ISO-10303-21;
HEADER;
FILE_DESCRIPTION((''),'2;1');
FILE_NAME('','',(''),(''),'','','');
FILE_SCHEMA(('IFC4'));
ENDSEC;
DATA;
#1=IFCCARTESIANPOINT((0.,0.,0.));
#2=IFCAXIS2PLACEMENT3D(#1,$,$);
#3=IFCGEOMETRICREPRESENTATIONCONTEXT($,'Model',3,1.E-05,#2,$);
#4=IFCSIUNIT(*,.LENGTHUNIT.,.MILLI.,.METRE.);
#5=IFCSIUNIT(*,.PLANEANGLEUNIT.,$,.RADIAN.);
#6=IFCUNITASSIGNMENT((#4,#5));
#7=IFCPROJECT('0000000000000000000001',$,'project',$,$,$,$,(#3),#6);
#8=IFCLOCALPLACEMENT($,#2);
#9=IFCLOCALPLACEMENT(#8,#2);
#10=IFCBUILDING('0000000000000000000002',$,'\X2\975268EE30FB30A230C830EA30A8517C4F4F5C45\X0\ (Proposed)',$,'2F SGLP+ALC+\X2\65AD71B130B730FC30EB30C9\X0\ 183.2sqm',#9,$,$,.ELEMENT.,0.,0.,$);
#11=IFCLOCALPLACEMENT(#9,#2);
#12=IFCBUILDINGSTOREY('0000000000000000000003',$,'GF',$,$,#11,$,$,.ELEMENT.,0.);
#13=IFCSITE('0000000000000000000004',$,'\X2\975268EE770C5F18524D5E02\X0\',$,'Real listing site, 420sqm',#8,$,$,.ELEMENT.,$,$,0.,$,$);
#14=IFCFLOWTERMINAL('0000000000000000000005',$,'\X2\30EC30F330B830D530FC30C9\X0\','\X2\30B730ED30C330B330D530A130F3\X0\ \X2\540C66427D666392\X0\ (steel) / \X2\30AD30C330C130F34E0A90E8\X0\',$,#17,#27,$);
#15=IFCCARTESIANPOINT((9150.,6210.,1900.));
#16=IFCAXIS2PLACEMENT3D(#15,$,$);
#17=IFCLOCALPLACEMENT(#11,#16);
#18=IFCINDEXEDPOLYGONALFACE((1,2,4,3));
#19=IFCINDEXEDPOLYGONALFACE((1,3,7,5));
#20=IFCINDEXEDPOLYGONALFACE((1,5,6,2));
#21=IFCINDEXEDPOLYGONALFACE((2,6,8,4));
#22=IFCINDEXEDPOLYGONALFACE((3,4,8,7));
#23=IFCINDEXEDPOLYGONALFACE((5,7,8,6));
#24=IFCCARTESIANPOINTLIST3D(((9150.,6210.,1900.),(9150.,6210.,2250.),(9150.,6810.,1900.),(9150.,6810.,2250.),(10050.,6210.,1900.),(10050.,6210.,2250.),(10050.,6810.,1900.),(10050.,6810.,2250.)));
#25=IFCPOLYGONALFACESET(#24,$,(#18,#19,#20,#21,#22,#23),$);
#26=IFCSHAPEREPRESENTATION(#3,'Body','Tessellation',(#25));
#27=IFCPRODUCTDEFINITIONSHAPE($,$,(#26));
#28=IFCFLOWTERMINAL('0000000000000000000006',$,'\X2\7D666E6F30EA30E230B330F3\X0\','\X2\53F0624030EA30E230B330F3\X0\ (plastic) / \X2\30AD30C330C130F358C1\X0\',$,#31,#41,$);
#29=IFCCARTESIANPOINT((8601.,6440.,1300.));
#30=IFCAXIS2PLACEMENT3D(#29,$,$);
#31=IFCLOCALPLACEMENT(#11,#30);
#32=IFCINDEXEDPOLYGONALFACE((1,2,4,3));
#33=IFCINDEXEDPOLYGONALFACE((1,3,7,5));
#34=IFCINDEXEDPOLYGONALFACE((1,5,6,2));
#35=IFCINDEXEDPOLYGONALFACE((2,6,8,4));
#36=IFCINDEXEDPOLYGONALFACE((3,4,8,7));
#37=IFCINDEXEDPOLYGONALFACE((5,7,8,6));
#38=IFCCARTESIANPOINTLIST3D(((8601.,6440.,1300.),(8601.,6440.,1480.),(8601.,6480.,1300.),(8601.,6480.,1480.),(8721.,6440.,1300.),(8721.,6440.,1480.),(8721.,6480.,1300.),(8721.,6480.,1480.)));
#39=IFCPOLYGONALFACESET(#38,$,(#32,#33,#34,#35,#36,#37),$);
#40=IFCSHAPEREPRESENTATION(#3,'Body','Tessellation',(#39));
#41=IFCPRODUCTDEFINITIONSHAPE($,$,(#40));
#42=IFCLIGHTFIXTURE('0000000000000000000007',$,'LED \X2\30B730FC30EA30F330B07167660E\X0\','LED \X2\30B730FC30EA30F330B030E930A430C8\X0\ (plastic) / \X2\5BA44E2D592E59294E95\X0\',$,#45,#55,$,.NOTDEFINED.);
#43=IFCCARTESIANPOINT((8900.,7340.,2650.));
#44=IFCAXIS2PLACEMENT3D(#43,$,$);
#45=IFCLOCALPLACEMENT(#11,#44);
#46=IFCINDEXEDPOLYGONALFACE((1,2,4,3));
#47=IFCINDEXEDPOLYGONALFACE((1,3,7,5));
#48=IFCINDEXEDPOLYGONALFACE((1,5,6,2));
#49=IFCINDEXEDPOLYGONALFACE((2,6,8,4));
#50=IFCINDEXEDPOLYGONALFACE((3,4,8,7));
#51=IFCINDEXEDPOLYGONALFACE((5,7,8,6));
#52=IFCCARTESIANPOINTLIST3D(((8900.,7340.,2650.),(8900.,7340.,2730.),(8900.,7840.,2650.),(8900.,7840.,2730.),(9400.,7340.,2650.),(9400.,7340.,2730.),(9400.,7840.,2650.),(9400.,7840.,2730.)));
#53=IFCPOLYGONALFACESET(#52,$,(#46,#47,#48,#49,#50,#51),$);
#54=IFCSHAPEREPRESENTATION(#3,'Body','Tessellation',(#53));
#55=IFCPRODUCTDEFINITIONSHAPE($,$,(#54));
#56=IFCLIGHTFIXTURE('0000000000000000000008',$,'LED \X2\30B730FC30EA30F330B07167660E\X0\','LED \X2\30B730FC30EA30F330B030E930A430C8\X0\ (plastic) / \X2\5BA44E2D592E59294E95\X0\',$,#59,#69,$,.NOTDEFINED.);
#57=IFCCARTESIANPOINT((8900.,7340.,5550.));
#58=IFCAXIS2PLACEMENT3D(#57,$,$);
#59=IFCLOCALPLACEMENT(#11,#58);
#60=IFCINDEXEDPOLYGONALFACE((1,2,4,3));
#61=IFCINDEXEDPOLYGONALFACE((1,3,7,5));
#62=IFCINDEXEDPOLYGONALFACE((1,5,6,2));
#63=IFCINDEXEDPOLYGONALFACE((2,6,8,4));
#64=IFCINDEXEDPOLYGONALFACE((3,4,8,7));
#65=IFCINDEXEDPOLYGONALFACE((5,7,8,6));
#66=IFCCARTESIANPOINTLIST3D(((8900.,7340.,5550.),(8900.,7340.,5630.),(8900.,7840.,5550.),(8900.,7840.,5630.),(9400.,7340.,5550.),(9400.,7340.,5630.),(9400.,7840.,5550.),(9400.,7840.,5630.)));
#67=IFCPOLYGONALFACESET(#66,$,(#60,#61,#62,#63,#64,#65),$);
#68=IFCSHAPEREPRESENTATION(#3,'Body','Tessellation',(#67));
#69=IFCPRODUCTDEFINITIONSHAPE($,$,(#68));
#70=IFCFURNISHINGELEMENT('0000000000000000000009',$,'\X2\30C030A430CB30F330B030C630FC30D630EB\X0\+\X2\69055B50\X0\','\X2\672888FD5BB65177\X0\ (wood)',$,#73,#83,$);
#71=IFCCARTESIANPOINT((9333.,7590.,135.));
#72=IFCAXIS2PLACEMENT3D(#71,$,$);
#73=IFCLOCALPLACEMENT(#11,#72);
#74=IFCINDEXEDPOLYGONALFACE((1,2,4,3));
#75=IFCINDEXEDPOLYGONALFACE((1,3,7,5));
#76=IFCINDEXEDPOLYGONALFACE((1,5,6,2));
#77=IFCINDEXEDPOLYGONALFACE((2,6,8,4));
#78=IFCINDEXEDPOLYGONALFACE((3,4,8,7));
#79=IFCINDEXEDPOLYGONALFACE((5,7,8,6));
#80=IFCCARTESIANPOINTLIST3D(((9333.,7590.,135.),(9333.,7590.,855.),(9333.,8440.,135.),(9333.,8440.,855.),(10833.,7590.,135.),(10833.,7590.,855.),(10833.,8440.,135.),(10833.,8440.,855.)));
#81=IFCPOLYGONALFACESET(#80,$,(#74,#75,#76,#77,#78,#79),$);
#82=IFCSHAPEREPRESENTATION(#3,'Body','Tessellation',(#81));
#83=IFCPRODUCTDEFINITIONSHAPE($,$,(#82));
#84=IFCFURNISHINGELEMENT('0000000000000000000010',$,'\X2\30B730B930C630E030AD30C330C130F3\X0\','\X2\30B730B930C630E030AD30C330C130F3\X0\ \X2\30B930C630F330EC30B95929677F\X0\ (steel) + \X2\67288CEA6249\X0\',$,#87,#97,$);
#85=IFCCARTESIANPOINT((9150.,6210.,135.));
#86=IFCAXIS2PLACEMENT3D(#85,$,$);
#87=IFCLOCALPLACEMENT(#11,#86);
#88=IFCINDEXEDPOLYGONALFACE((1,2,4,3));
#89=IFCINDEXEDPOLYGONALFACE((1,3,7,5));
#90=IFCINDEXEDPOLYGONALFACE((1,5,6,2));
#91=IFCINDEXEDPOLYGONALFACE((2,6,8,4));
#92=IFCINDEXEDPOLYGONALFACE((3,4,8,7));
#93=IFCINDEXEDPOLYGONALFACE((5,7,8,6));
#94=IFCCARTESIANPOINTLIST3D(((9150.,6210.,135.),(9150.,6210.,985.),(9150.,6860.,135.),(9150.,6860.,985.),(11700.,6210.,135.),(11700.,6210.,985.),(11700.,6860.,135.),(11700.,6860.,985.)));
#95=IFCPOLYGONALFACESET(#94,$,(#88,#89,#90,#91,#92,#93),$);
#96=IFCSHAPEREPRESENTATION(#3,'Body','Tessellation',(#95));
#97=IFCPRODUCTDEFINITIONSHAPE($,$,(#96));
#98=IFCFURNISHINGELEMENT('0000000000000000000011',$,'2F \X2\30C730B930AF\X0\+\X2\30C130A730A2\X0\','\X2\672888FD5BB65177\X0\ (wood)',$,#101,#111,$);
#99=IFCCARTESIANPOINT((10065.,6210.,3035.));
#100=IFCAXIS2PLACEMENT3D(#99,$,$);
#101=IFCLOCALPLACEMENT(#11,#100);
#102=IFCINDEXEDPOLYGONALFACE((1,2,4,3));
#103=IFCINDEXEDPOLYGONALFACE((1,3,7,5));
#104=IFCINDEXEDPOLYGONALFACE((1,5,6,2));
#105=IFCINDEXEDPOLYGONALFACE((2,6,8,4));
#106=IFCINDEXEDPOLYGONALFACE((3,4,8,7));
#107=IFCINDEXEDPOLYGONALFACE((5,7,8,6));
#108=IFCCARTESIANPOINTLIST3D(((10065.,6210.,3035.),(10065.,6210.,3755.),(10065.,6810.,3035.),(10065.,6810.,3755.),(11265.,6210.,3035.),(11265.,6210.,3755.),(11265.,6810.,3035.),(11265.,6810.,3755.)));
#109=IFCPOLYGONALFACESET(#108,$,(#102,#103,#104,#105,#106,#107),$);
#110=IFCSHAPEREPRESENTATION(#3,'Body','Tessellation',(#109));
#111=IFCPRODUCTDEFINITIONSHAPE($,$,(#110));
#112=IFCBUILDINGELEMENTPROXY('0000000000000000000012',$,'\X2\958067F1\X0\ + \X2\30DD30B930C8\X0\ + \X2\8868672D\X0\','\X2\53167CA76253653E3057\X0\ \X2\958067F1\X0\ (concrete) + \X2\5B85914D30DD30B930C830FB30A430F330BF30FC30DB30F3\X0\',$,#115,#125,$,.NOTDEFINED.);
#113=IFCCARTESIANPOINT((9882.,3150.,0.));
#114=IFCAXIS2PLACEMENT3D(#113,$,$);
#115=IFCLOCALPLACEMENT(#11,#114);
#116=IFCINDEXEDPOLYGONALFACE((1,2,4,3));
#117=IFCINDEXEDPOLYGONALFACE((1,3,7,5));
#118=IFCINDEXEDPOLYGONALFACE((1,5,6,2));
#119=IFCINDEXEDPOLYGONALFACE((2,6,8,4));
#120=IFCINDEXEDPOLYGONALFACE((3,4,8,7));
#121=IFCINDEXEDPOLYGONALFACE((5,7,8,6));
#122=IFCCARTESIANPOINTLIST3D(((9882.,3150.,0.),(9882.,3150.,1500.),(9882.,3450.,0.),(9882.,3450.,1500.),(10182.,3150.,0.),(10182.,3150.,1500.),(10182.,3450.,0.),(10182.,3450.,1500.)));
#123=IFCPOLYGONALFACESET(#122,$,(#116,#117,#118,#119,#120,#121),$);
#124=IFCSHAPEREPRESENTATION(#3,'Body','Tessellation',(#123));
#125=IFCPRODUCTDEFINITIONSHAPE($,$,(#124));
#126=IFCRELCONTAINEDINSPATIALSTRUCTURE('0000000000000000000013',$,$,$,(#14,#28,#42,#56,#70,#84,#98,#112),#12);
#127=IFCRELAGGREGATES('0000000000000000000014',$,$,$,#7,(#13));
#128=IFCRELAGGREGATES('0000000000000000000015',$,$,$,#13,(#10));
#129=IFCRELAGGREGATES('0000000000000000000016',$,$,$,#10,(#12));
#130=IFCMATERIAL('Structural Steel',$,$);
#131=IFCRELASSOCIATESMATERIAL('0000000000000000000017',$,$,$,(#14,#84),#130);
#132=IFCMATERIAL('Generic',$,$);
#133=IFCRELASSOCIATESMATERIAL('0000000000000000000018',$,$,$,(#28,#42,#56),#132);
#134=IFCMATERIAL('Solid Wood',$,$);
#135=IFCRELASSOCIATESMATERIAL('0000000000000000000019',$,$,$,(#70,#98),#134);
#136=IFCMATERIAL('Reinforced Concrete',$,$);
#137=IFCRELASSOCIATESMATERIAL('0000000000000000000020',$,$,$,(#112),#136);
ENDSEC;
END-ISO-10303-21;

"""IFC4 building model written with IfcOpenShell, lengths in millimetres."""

from ifc_helpers import new_model, si_unit, frame, frame_2d, origin, place, context, project, spatial, rectangle, extrude, material, element, save


model = new_model("IFC4")

# Units and contexts
model_context = context("Model", 3, precision=1e-05, world=origin())
ifc_project = project(units=[si_unit("LENGTHUNIT", "METRE", prefix="MILLI"), si_unit("PLANEANGLEUNIT", "RADIAN")], contexts=[model_context])

# Site, building, storey
site_placement = place(None, origin())
site = spatial("IfcSite", under=ifc_project, at=site_placement, Name="青森県弘前市", ObjectType="Real listing site, 420sqm", CompositionType="ELEMENT", RefElevation=0.0)
building_placement = place(site_placement, origin())
building = spatial("IfcBuilding", under=site, at=building_placement, Name="青森・アトリエ兼住居 (Proposed)", ObjectType="2F SGLP+ALC+断熱シールド 183.2sqm", CompositionType="ELEMENT", ElevationOfRefHeight=0.0, ElevationOfTerrain=0.0)
storey_placement = place(building_placement, origin())
storey = spatial("IfcBuildingStorey", under=building, at=storey_placement, Name="GF", CompositionType="ELEMENT", Elevation=0.0)

# Shared definitions
ifc_material_1 = material(Name="Solid Wood")

# Shared definitions
ifc_material_2 = material(Name="Structural Steel")

# Shared definitions
ifc_material_3 = material(Name="Reinforced Concrete")

# Flow terminals
flow_terminal_1_placement = place(storey_placement, frame((9150.0, 6210.0, 1900.0)))
element("IfcFlowTerminal", 1, at=flow_terminal_1_placement, inside=storey, material=ifc_material_2, Name="レンジフード", Description="シロッコファン 同時給排 (steel) / キッチン上部", context=model_context, shape_type="SweptSolid", body=[
    extrude(rectangle(XDim=900.0, YDim=600.0, at=frame_2d((450.0, 300.0))), frame((9150.0, 6210.0, 1900.0)), (0.0, 0.0, 1.0), 350.0),
])
ifc_material_4 = material(Name="Generic")
flow_terminal_2_placement = place(storey_placement, frame((8601.0, 6440.0, 1300.0)))
element("IfcFlowTerminal", 2, at=flow_terminal_2_placement, inside=storey, material=ifc_material_4, Name="給湯リモコン", Description="台所リモコン (plastic) / キッチン壁", context=model_context, shape_type="SweptSolid", body=[
    extrude(rectangle(XDim=120.0, YDim=40.0, at=frame_2d((60.0, 20.0))), frame((8601.0, 6440.0, 1300.0)), (0.0, 0.0, 1.0), 180.0),
])

# Light fixtures
light_fixture_1_placement = place(storey_placement, frame((8900.0, 7340.0, 2650.0)))
element("IfcLightFixture", 3, at=light_fixture_1_placement, inside=storey, material=ifc_material_4, Name="LED シーリング照明", Description="LED シーリングライト (plastic) / 室中央天井", PredefinedType="NOTDEFINED", context=model_context, shape_type="SweptSolid", body=[
    extrude(rectangle(XDim=500.0, YDim=500.0, at=frame_2d((250.0, 250.0))), frame((8900.0, 7340.0, 2650.0)), (0.0, 0.0, 1.0), 80.0),
])
light_fixture_2_placement = place(storey_placement, frame((8900.0, 7340.0, 5550.0)))
element("IfcLightFixture", 4, at=light_fixture_2_placement, inside=storey, material=ifc_material_4, Name="LED シーリング照明", Description="LED シーリングライト (plastic) / 室中央天井", PredefinedType="NOTDEFINED", context=model_context, shape_type="SweptSolid", body=[
    extrude(rectangle(XDim=500.0, YDim=500.0, at=frame_2d((250.0, 250.0))), frame((8900.0, 7340.0, 5550.0)), (0.0, 0.0, 1.0), 80.0),
])

# Furnishing elements
furnishing_1_placement = place(storey_placement, frame((9333.0, 7590.0, 135.0)))
element("IfcFurnishingElement", 5, at=furnishing_1_placement, inside=storey, material=ifc_material_1, Name="ダイニングテーブル+椅子", Description="木製家具 (wood)", context=model_context, shape_type="SweptSolid", body=[
    extrude(rectangle(XDim=1500.0, YDim=850.0, at=frame_2d((750.0, 425.0))), frame((9333.0, 7590.0, 135.0)), (0.0, 0.0, 1.0), 720.0),
])
furnishing_2_placement = place(storey_placement, frame((9150.0, 6210.0, 135.0)))
element("IfcFurnishingElement", 6, at=furnishing_2_placement, inside=storey, material=ifc_material_2, Name="システムキッチン", Description="システムキッチン ステンレス天板 (steel) + 木質扉", context=model_context, shape_type="SweptSolid", body=[
    extrude(rectangle(XDim=2550.0, YDim=650.0, at=frame_2d((1275.0, 325.0))), frame((9150.0, 6210.0, 135.0)), (0.0, 0.0, 1.0), 850.0),
])
furnishing_3_placement = place(storey_placement, frame((10065.0, 6210.0, 3035.0)))
element("IfcFurnishingElement", 7, at=furnishing_3_placement, inside=storey, material=ifc_material_1, Name="2F デスク+チェア", Description="木製家具 (wood)", context=model_context, shape_type="SweptSolid", body=[
    extrude(rectangle(XDim=1200.0, YDim=600.0, at=frame_2d((600.0, 300.0))), frame((10065.0, 6210.0, 3035.0)), (0.0, 0.0, 1.0), 720.0),
])

# Building element proxy
proxy_placement = place(storey_placement, frame((9882.0, 3150.0, 0.0)))
element("IfcBuildingElementProxy", 8, at=proxy_placement, inside=storey, material=ifc_material_3, Name="門柱 + ポスト + 表札", Description="化粧打放し 門柱 (concrete) + 宅配ポスト・インターホン", PredefinedType="NOTDEFINED", context=model_context, shape_type="SweptSolid", body=[
    extrude(rectangle(XDim=300.0, YDim=300.0, at=frame_2d((150.0, 150.0))), frame((9882.0, 3150.0, 0.0)), (0.0, 0.0, 1.0), 1500.0),
])

save(model, "model.ifc")
